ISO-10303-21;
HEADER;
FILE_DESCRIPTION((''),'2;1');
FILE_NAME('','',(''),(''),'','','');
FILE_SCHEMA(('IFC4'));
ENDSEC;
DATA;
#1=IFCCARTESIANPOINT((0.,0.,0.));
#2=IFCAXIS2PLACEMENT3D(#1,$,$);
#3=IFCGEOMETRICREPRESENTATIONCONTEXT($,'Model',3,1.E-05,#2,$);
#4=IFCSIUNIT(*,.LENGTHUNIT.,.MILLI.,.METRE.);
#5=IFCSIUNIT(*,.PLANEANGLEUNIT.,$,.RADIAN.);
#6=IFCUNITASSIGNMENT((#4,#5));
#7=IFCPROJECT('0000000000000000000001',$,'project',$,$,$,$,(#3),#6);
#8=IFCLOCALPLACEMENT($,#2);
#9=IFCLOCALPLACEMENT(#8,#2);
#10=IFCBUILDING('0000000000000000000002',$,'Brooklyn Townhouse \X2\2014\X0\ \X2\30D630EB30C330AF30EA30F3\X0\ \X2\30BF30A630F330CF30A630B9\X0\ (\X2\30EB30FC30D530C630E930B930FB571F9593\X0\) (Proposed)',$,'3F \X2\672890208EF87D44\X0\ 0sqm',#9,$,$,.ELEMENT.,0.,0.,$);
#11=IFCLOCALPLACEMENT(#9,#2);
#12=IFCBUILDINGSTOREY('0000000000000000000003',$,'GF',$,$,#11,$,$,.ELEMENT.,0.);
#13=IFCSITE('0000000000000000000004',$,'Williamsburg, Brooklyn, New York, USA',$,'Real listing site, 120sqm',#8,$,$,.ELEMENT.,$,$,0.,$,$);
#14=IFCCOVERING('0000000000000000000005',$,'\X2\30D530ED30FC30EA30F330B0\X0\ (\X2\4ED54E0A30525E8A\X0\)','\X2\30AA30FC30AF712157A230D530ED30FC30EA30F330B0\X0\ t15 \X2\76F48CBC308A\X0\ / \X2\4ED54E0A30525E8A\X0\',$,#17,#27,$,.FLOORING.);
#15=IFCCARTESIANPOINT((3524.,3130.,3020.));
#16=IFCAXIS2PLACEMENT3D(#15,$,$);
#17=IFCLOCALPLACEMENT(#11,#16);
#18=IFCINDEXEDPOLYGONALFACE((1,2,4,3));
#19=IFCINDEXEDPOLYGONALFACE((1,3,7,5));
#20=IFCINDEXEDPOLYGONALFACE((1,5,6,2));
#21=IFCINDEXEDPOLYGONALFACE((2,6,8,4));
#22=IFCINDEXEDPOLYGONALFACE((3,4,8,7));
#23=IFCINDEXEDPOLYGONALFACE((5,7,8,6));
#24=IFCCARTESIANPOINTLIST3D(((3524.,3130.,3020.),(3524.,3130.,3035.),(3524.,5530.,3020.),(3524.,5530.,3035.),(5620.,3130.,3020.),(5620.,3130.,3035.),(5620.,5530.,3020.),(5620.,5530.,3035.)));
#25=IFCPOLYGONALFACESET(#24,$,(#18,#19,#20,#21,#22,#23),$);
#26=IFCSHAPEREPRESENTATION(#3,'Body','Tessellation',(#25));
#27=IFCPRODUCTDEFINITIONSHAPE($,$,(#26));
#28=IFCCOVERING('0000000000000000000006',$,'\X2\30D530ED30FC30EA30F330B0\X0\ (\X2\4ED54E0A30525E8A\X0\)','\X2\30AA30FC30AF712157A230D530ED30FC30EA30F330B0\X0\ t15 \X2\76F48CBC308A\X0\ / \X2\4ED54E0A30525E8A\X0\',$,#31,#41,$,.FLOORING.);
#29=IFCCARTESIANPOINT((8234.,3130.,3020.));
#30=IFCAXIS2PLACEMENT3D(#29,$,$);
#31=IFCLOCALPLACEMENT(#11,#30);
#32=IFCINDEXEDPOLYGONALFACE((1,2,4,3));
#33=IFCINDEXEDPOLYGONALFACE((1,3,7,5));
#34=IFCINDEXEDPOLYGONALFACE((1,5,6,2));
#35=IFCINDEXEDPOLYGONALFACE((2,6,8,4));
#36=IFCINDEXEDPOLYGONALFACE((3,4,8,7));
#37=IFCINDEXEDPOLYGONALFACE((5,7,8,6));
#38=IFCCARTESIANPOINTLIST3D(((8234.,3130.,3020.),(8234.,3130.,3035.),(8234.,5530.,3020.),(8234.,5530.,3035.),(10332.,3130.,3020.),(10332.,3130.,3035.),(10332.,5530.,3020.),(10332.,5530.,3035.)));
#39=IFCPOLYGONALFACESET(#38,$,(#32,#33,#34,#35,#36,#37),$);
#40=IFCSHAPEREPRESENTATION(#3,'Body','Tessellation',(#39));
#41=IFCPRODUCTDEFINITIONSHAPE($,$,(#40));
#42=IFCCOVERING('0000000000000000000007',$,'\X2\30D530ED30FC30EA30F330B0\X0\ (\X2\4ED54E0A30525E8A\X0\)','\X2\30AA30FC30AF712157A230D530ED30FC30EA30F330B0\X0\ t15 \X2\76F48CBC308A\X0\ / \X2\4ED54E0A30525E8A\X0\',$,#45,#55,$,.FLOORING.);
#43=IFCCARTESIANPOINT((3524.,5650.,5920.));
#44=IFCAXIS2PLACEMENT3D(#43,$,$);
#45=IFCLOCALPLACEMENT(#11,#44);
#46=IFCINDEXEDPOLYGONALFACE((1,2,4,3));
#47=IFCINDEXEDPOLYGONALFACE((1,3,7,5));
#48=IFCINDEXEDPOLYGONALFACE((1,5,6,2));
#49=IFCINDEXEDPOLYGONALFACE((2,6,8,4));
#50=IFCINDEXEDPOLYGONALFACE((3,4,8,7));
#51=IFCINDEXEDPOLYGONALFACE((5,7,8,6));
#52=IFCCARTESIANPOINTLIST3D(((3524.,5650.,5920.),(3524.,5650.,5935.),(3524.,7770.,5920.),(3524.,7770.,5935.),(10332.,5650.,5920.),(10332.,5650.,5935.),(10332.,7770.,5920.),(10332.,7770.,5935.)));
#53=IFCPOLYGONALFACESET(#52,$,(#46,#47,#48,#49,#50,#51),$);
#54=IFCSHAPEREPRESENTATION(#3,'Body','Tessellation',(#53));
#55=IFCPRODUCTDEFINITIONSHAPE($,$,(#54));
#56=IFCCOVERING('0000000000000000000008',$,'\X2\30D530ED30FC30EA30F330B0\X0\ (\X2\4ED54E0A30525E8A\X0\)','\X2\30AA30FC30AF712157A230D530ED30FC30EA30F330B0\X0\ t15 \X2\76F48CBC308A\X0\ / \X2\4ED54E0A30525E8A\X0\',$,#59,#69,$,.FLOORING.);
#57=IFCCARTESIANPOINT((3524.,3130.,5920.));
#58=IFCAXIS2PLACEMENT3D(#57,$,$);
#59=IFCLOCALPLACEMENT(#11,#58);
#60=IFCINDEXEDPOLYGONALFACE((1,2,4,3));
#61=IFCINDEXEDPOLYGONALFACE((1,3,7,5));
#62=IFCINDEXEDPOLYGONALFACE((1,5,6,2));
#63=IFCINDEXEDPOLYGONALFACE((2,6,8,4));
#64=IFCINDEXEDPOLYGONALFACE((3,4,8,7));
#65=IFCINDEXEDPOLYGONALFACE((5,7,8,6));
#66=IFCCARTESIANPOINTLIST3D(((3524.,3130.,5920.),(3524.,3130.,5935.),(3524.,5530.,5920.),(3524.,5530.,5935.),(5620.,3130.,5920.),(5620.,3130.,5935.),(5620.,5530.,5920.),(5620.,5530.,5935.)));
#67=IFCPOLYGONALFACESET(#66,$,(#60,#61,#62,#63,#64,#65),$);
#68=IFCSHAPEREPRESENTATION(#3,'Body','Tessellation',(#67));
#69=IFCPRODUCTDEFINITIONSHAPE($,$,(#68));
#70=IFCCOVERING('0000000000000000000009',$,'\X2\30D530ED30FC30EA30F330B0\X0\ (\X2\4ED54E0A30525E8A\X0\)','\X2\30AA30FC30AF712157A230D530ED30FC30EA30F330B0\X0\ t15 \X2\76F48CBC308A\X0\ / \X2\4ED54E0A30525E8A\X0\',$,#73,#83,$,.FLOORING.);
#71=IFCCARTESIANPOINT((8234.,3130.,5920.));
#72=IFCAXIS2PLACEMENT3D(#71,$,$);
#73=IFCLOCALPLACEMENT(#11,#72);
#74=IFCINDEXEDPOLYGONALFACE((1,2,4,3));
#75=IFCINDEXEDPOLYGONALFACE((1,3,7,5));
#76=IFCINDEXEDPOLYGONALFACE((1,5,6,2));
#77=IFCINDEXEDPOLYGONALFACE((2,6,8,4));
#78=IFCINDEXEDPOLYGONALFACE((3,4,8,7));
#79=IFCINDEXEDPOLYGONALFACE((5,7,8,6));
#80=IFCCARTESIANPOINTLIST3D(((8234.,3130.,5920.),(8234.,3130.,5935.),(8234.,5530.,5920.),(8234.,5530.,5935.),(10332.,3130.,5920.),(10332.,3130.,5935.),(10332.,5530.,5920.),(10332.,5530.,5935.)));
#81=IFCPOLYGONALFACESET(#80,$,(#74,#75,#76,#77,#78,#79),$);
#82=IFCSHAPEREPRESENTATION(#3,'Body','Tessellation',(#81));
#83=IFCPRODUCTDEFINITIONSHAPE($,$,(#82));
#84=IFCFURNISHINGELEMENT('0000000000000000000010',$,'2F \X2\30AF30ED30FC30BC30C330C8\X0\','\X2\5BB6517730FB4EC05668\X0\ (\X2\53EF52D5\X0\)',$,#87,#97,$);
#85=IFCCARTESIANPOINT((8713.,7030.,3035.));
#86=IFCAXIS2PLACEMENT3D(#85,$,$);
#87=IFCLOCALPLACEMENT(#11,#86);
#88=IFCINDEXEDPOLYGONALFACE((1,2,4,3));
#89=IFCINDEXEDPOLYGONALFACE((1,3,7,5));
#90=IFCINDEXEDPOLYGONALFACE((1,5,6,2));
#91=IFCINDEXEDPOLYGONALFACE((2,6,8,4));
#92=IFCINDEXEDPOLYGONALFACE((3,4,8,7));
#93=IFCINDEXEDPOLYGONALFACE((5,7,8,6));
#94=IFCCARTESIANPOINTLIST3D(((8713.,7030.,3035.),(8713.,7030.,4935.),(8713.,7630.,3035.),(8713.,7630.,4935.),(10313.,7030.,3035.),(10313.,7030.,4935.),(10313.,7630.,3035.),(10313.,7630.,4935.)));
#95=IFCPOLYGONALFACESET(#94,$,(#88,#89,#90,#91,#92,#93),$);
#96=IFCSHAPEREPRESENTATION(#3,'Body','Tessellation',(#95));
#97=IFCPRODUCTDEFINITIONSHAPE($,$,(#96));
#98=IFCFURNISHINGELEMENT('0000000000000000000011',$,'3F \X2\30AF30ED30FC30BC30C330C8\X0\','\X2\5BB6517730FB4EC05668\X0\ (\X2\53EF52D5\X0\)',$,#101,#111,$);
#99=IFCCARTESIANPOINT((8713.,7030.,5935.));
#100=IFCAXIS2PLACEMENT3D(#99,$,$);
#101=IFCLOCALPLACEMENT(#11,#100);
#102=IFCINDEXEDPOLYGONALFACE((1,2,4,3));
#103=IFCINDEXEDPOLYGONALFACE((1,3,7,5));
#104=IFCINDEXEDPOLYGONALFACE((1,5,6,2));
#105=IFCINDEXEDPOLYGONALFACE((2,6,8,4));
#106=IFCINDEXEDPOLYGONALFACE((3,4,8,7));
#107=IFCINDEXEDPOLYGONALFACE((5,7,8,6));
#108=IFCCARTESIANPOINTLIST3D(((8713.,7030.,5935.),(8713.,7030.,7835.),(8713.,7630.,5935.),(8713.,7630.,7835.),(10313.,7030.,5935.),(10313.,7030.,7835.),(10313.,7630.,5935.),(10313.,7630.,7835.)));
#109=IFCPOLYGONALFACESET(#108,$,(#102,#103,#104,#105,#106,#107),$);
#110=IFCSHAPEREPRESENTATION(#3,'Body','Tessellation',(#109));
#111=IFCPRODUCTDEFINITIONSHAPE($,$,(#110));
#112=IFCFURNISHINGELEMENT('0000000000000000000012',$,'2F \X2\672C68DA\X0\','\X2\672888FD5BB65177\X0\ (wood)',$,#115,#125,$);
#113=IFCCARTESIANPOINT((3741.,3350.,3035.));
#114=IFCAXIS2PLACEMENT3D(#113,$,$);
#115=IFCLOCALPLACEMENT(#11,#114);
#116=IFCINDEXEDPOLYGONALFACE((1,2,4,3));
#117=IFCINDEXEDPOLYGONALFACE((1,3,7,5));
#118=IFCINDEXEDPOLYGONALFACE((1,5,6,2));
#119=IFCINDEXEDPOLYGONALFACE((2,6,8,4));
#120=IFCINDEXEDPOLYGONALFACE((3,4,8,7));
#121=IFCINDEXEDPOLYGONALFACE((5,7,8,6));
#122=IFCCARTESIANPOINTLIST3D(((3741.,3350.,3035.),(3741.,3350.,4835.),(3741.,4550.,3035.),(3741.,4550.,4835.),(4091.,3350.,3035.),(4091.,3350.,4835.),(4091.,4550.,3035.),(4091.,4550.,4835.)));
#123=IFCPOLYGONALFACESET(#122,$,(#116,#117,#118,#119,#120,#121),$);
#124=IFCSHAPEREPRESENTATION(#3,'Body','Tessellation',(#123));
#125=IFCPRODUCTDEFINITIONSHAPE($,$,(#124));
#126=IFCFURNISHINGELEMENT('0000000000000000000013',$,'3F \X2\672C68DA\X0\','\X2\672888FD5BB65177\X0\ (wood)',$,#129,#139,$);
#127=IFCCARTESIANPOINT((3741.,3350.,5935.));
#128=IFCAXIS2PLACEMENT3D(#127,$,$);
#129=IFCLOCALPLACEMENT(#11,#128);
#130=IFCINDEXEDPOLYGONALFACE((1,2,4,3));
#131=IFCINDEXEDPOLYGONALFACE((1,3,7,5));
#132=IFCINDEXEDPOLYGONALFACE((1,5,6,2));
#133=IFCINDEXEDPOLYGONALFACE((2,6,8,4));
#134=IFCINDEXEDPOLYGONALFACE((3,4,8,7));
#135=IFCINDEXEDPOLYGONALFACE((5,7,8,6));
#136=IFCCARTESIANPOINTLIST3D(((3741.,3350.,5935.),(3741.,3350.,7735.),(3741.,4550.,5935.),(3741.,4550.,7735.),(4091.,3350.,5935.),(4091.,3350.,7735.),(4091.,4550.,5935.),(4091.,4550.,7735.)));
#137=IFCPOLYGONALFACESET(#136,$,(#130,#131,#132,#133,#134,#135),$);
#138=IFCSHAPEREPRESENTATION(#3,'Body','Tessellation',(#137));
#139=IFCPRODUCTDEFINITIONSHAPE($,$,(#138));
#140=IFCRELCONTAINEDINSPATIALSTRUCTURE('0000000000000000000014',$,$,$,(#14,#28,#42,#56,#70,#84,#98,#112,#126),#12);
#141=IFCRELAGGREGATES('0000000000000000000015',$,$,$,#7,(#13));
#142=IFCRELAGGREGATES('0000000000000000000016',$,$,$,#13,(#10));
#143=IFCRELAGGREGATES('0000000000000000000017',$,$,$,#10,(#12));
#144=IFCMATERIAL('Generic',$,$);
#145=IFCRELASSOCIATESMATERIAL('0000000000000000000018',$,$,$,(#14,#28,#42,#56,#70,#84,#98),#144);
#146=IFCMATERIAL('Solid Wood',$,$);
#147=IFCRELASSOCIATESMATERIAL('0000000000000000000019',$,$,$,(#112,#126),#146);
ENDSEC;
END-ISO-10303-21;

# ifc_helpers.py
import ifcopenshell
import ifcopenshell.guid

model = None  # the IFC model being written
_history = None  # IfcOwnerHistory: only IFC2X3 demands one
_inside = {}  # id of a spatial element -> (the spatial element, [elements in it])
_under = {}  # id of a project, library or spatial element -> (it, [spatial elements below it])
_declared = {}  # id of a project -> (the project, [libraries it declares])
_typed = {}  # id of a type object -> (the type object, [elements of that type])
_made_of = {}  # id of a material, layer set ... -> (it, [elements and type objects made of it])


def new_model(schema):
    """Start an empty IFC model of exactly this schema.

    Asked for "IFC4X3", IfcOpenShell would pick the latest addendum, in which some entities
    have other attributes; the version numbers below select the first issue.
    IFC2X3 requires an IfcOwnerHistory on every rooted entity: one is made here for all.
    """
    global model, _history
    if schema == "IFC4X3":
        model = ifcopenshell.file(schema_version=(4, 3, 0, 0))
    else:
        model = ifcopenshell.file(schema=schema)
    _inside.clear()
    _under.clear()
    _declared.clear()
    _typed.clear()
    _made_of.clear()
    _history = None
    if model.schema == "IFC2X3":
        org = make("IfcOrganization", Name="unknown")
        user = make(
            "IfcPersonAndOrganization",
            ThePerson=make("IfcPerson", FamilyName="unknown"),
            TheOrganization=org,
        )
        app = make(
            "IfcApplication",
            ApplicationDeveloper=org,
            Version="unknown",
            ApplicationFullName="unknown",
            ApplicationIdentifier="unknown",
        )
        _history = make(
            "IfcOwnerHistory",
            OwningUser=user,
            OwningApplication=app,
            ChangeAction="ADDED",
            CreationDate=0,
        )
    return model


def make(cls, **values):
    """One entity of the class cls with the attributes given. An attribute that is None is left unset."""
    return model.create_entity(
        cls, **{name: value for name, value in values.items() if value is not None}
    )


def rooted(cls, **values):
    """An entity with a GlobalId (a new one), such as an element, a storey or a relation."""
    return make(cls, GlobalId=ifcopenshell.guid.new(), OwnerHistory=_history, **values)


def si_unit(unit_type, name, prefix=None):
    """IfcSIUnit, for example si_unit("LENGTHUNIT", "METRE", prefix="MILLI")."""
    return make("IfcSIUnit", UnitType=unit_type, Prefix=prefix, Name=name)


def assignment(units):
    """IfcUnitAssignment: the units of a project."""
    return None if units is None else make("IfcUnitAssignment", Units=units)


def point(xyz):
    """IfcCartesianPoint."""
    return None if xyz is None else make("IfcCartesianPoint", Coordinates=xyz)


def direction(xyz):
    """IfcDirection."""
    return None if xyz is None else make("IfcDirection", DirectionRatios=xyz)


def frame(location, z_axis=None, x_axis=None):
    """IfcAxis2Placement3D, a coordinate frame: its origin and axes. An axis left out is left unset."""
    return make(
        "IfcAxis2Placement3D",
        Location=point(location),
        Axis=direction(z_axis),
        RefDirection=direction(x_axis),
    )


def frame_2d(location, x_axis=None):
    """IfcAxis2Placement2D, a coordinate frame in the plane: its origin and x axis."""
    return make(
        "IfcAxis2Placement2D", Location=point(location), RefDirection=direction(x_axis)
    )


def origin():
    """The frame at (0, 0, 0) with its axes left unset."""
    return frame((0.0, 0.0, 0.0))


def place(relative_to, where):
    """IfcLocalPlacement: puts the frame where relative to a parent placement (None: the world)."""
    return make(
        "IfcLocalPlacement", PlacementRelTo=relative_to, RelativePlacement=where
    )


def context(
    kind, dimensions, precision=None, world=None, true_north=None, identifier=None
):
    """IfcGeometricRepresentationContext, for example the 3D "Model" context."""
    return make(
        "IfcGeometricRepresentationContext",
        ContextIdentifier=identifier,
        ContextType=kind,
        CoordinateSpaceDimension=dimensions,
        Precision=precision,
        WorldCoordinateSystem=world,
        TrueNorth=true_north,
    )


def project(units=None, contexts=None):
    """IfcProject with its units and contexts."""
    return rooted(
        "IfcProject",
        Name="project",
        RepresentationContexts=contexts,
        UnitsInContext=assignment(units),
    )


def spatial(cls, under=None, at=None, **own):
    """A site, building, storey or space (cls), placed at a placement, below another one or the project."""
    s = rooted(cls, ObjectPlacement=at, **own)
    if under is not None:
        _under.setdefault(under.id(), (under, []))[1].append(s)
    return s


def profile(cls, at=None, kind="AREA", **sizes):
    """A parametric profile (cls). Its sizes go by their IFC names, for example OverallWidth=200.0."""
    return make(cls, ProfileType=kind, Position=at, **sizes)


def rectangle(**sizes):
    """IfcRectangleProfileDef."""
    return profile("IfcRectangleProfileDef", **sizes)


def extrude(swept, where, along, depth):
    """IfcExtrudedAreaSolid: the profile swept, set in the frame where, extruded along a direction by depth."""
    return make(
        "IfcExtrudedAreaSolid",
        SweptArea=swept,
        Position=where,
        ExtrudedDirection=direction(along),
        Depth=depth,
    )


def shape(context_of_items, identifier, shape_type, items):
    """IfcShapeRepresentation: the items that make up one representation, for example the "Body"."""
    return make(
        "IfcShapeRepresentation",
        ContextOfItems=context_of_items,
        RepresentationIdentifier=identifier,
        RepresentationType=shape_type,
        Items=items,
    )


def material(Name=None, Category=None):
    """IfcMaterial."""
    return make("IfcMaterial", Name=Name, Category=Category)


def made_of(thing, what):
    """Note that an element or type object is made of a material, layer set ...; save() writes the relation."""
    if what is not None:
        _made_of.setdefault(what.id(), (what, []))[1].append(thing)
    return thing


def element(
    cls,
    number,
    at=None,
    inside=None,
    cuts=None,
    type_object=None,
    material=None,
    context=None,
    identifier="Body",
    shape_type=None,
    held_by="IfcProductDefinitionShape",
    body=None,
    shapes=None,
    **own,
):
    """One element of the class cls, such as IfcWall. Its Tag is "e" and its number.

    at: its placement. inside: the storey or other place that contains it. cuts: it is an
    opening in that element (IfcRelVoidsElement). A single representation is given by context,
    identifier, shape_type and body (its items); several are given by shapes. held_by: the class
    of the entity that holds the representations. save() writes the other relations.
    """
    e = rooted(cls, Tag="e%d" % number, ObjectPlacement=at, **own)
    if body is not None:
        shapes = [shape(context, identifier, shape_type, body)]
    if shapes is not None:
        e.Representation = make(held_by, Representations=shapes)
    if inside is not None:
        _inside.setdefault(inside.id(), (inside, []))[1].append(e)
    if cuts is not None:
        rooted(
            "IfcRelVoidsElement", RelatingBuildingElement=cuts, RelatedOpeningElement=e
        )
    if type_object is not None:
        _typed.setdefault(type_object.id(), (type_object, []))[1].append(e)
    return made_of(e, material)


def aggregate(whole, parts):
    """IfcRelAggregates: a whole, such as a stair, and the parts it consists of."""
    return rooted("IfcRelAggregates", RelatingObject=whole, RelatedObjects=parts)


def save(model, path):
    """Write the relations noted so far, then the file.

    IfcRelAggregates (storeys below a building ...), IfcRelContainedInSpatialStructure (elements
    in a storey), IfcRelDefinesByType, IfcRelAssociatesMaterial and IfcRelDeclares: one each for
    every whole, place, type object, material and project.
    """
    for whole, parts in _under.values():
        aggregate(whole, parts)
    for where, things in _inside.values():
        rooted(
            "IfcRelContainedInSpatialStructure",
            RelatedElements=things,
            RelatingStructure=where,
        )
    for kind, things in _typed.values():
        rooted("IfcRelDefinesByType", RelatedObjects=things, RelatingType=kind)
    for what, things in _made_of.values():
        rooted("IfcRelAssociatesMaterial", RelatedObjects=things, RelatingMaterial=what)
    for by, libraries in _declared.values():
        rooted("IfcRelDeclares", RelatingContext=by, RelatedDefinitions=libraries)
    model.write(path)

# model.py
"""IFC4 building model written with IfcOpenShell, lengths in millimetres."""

from ifc_helpers import new_model, si_unit, frame, frame_2d, origin, place, context, project, spatial, rectangle, extrude, material, element, save


model = new_model("IFC4")

# Units and contexts
model_context = context("Model", 3, precision=1e-05, world=origin())
ifc_project = project(units=[si_unit("LENGTHUNIT", "METRE", prefix="MILLI"), si_unit("PLANEANGLEUNIT", "RADIAN")], contexts=[model_context])

# Site, building, storey
site_placement = place(None, origin())
site = spatial("IfcSite", under=ifc_project, at=site_placement, Name="Williamsburg, Brooklyn, New York, USA", ObjectType="Real listing site, 120sqm", CompositionType="ELEMENT", RefElevation=0.0)
building_placement = place(site_placement, origin())
building = spatial("IfcBuilding", under=site, at=building_placement, Name="Brooklyn Townhouse — ブルックリン タウンハウス (ルーフテラス・土間) (Proposed)", ObjectType="3F 木造軸組 0sqm", CompositionType="ELEMENT", ElevationOfRefHeight=0.0, ElevationOfTerrain=0.0)
storey_placement = place(building_placement, origin())
storey = spatial("IfcBuildingStorey", under=building, at=storey_placement, Name="GF", CompositionType="ELEMENT", Elevation=0.0)

# Shared definitions
ifc_material_1 = material(Name="Solid Wood")

# Coverings
ifc_material_2 = material(Name="Generic")
covering_1_placement = place(storey_placement, frame((3524.0, 3130.0, 3020.0)))
element("IfcCovering", 1, at=covering_1_placement, inside=storey, material=ifc_material_2, Name="フローリング (仕上げ床)", Description="オーク無垢フローリング t15 直貼り / 仕上げ床", PredefinedType="FLOORING", context=model_context, shape_type="SweptSolid", body=[
    extrude(rectangle(XDim=2096.0, YDim=2400.0, at=frame_2d((1048.0, 1200.0))), frame((3524.0, 3130.0, 3020.0)), (0.0, 0.0, 1.0), 15.0),
])
covering_2_placement = place(storey_placement, frame((8234.0, 3130.0, 3020.0)))
element("IfcCovering", 2, at=covering_2_placement, inside=storey, material=ifc_material_2, Name="フローリング (仕上げ床)", Description="オーク無垢フローリング t15 直貼り / 仕上げ床", PredefinedType="FLOORING", context=model_context, shape_type="SweptSolid", body=[
    extrude(rectangle(XDim=2098.0, YDim=2400.0, at=frame_2d((1049.0, 1200.0))), frame((8234.0, 3130.0, 3020.0)), (0.0, 0.0, 1.0), 15.0),
])
covering_3_placement = place(storey_placement, frame((3524.0, 5650.0, 5920.0)))
element("IfcCovering", 3, at=covering_3_placement, inside=storey, material=ifc_material_2, Name="フローリング (仕上げ床)", Description="オーク無垢フローリング t15 直貼り / 仕上げ床", PredefinedType="FLOORING", context=model_context, shape_type="SweptSolid", body=[
    extrude(rectangle(XDim=6808.0, YDim=2120.0, at=frame_2d((3404.0, 1060.0))), frame((3524.0, 5650.0, 5920.0)), (0.0, 0.0, 1.0), 15.0),
])
covering_4_placement = place(storey_placement, frame((3524.0, 3130.0, 5920.0)))
element("IfcCovering", 4, at=covering_4_placement, inside=storey, material=ifc_material_2, Name="フローリング (仕上げ床)", Description="オーク無垢フローリング t15 直貼り / 仕上げ床", PredefinedType="FLOORING", context=model_context, shape_type="SweptSolid", body=[
    extrude(rectangle(XDim=2096.0, YDim=2400.0, at=frame_2d((1048.0, 1200.0))), frame((3524.0, 3130.0, 5920.0)), (0.0, 0.0, 1.0), 15.0),
])
covering_5_placement = place(storey_placement, frame((8234.0, 3130.0, 5920.0)))
element("IfcCovering", 5, at=covering_5_placement, inside=storey, material=ifc_material_2, Name="フローリング (仕上げ床)", Description="オーク無垢フローリング t15 直貼り / 仕上げ床", PredefinedType="FLOORING", context=model_context, shape_type="SweptSolid", body=[
    extrude(rectangle(XDim=2098.0, YDim=2400.0, at=frame_2d((1049.0, 1200.0))), frame((8234.0, 3130.0, 5920.0)), (0.0, 0.0, 1.0), 15.0),
])

# Furnishing elements
furnishing_1_placement = place(storey_placement, frame((8713.0, 7030.0, 3035.0)))
element("IfcFurnishingElement", 6, at=furnishing_1_placement, inside=storey, material=ifc_material_2, Name="2F クローゼット", Description="家具・什器 (可動)", context=model_context, shape_type="SweptSolid", body=[
    extrude(rectangle(XDim=1600.0, YDim=600.0, at=frame_2d((800.0, 300.0))), frame((8713.0, 7030.0, 3035.0)), (0.0, 0.0, 1.0), 1900.0),
])
furnishing_2_placement = place(storey_placement, frame((8713.0, 7030.0, 5935.0)))
element("IfcFurnishingElement", 7, at=furnishing_2_placement, inside=storey, material=ifc_material_2, Name="3F クローゼット", Description="家具・什器 (可動)", context=model_context, shape_type="SweptSolid", body=[
    extrude(rectangle(XDim=1600.0, YDim=600.0, at=frame_2d((800.0, 300.0))), frame((8713.0, 7030.0, 5935.0)), (0.0, 0.0, 1.0), 1900.0),
])
furnishing_3_placement = place(storey_placement, frame((3741.0, 3350.0, 3035.0)))
element("IfcFurnishingElement", 8, at=furnishing_3_placement, inside=storey, material=ifc_material_1, Name="2F 本棚", Description="木製家具 (wood)", context=model_context, shape_type="SweptSolid", body=[
    extrude(rectangle(XDim=350.0, YDim=1200.0, at=frame_2d((175.0, 600.0))), frame((3741.0, 3350.0, 3035.0)), (0.0, 0.0, 1.0), 1800.0),
])
furnishing_4_placement = place(storey_placement, frame((3741.0, 3350.0, 5935.0)))
element("IfcFurnishingElement", 9, at=furnishing_4_placement, inside=storey, material=ifc_material_1, Name="3F 本棚", Description="木製家具 (wood)", context=model_context, shape_type="SweptSolid", body=[
    extrude(rectangle(XDim=350.0, YDim=1200.0, at=frame_2d((175.0, 600.0))), frame((3741.0, 3350.0, 5935.0)), (0.0, 0.0, 1.0), 1800.0),
])

save(model, "model.ifc")
